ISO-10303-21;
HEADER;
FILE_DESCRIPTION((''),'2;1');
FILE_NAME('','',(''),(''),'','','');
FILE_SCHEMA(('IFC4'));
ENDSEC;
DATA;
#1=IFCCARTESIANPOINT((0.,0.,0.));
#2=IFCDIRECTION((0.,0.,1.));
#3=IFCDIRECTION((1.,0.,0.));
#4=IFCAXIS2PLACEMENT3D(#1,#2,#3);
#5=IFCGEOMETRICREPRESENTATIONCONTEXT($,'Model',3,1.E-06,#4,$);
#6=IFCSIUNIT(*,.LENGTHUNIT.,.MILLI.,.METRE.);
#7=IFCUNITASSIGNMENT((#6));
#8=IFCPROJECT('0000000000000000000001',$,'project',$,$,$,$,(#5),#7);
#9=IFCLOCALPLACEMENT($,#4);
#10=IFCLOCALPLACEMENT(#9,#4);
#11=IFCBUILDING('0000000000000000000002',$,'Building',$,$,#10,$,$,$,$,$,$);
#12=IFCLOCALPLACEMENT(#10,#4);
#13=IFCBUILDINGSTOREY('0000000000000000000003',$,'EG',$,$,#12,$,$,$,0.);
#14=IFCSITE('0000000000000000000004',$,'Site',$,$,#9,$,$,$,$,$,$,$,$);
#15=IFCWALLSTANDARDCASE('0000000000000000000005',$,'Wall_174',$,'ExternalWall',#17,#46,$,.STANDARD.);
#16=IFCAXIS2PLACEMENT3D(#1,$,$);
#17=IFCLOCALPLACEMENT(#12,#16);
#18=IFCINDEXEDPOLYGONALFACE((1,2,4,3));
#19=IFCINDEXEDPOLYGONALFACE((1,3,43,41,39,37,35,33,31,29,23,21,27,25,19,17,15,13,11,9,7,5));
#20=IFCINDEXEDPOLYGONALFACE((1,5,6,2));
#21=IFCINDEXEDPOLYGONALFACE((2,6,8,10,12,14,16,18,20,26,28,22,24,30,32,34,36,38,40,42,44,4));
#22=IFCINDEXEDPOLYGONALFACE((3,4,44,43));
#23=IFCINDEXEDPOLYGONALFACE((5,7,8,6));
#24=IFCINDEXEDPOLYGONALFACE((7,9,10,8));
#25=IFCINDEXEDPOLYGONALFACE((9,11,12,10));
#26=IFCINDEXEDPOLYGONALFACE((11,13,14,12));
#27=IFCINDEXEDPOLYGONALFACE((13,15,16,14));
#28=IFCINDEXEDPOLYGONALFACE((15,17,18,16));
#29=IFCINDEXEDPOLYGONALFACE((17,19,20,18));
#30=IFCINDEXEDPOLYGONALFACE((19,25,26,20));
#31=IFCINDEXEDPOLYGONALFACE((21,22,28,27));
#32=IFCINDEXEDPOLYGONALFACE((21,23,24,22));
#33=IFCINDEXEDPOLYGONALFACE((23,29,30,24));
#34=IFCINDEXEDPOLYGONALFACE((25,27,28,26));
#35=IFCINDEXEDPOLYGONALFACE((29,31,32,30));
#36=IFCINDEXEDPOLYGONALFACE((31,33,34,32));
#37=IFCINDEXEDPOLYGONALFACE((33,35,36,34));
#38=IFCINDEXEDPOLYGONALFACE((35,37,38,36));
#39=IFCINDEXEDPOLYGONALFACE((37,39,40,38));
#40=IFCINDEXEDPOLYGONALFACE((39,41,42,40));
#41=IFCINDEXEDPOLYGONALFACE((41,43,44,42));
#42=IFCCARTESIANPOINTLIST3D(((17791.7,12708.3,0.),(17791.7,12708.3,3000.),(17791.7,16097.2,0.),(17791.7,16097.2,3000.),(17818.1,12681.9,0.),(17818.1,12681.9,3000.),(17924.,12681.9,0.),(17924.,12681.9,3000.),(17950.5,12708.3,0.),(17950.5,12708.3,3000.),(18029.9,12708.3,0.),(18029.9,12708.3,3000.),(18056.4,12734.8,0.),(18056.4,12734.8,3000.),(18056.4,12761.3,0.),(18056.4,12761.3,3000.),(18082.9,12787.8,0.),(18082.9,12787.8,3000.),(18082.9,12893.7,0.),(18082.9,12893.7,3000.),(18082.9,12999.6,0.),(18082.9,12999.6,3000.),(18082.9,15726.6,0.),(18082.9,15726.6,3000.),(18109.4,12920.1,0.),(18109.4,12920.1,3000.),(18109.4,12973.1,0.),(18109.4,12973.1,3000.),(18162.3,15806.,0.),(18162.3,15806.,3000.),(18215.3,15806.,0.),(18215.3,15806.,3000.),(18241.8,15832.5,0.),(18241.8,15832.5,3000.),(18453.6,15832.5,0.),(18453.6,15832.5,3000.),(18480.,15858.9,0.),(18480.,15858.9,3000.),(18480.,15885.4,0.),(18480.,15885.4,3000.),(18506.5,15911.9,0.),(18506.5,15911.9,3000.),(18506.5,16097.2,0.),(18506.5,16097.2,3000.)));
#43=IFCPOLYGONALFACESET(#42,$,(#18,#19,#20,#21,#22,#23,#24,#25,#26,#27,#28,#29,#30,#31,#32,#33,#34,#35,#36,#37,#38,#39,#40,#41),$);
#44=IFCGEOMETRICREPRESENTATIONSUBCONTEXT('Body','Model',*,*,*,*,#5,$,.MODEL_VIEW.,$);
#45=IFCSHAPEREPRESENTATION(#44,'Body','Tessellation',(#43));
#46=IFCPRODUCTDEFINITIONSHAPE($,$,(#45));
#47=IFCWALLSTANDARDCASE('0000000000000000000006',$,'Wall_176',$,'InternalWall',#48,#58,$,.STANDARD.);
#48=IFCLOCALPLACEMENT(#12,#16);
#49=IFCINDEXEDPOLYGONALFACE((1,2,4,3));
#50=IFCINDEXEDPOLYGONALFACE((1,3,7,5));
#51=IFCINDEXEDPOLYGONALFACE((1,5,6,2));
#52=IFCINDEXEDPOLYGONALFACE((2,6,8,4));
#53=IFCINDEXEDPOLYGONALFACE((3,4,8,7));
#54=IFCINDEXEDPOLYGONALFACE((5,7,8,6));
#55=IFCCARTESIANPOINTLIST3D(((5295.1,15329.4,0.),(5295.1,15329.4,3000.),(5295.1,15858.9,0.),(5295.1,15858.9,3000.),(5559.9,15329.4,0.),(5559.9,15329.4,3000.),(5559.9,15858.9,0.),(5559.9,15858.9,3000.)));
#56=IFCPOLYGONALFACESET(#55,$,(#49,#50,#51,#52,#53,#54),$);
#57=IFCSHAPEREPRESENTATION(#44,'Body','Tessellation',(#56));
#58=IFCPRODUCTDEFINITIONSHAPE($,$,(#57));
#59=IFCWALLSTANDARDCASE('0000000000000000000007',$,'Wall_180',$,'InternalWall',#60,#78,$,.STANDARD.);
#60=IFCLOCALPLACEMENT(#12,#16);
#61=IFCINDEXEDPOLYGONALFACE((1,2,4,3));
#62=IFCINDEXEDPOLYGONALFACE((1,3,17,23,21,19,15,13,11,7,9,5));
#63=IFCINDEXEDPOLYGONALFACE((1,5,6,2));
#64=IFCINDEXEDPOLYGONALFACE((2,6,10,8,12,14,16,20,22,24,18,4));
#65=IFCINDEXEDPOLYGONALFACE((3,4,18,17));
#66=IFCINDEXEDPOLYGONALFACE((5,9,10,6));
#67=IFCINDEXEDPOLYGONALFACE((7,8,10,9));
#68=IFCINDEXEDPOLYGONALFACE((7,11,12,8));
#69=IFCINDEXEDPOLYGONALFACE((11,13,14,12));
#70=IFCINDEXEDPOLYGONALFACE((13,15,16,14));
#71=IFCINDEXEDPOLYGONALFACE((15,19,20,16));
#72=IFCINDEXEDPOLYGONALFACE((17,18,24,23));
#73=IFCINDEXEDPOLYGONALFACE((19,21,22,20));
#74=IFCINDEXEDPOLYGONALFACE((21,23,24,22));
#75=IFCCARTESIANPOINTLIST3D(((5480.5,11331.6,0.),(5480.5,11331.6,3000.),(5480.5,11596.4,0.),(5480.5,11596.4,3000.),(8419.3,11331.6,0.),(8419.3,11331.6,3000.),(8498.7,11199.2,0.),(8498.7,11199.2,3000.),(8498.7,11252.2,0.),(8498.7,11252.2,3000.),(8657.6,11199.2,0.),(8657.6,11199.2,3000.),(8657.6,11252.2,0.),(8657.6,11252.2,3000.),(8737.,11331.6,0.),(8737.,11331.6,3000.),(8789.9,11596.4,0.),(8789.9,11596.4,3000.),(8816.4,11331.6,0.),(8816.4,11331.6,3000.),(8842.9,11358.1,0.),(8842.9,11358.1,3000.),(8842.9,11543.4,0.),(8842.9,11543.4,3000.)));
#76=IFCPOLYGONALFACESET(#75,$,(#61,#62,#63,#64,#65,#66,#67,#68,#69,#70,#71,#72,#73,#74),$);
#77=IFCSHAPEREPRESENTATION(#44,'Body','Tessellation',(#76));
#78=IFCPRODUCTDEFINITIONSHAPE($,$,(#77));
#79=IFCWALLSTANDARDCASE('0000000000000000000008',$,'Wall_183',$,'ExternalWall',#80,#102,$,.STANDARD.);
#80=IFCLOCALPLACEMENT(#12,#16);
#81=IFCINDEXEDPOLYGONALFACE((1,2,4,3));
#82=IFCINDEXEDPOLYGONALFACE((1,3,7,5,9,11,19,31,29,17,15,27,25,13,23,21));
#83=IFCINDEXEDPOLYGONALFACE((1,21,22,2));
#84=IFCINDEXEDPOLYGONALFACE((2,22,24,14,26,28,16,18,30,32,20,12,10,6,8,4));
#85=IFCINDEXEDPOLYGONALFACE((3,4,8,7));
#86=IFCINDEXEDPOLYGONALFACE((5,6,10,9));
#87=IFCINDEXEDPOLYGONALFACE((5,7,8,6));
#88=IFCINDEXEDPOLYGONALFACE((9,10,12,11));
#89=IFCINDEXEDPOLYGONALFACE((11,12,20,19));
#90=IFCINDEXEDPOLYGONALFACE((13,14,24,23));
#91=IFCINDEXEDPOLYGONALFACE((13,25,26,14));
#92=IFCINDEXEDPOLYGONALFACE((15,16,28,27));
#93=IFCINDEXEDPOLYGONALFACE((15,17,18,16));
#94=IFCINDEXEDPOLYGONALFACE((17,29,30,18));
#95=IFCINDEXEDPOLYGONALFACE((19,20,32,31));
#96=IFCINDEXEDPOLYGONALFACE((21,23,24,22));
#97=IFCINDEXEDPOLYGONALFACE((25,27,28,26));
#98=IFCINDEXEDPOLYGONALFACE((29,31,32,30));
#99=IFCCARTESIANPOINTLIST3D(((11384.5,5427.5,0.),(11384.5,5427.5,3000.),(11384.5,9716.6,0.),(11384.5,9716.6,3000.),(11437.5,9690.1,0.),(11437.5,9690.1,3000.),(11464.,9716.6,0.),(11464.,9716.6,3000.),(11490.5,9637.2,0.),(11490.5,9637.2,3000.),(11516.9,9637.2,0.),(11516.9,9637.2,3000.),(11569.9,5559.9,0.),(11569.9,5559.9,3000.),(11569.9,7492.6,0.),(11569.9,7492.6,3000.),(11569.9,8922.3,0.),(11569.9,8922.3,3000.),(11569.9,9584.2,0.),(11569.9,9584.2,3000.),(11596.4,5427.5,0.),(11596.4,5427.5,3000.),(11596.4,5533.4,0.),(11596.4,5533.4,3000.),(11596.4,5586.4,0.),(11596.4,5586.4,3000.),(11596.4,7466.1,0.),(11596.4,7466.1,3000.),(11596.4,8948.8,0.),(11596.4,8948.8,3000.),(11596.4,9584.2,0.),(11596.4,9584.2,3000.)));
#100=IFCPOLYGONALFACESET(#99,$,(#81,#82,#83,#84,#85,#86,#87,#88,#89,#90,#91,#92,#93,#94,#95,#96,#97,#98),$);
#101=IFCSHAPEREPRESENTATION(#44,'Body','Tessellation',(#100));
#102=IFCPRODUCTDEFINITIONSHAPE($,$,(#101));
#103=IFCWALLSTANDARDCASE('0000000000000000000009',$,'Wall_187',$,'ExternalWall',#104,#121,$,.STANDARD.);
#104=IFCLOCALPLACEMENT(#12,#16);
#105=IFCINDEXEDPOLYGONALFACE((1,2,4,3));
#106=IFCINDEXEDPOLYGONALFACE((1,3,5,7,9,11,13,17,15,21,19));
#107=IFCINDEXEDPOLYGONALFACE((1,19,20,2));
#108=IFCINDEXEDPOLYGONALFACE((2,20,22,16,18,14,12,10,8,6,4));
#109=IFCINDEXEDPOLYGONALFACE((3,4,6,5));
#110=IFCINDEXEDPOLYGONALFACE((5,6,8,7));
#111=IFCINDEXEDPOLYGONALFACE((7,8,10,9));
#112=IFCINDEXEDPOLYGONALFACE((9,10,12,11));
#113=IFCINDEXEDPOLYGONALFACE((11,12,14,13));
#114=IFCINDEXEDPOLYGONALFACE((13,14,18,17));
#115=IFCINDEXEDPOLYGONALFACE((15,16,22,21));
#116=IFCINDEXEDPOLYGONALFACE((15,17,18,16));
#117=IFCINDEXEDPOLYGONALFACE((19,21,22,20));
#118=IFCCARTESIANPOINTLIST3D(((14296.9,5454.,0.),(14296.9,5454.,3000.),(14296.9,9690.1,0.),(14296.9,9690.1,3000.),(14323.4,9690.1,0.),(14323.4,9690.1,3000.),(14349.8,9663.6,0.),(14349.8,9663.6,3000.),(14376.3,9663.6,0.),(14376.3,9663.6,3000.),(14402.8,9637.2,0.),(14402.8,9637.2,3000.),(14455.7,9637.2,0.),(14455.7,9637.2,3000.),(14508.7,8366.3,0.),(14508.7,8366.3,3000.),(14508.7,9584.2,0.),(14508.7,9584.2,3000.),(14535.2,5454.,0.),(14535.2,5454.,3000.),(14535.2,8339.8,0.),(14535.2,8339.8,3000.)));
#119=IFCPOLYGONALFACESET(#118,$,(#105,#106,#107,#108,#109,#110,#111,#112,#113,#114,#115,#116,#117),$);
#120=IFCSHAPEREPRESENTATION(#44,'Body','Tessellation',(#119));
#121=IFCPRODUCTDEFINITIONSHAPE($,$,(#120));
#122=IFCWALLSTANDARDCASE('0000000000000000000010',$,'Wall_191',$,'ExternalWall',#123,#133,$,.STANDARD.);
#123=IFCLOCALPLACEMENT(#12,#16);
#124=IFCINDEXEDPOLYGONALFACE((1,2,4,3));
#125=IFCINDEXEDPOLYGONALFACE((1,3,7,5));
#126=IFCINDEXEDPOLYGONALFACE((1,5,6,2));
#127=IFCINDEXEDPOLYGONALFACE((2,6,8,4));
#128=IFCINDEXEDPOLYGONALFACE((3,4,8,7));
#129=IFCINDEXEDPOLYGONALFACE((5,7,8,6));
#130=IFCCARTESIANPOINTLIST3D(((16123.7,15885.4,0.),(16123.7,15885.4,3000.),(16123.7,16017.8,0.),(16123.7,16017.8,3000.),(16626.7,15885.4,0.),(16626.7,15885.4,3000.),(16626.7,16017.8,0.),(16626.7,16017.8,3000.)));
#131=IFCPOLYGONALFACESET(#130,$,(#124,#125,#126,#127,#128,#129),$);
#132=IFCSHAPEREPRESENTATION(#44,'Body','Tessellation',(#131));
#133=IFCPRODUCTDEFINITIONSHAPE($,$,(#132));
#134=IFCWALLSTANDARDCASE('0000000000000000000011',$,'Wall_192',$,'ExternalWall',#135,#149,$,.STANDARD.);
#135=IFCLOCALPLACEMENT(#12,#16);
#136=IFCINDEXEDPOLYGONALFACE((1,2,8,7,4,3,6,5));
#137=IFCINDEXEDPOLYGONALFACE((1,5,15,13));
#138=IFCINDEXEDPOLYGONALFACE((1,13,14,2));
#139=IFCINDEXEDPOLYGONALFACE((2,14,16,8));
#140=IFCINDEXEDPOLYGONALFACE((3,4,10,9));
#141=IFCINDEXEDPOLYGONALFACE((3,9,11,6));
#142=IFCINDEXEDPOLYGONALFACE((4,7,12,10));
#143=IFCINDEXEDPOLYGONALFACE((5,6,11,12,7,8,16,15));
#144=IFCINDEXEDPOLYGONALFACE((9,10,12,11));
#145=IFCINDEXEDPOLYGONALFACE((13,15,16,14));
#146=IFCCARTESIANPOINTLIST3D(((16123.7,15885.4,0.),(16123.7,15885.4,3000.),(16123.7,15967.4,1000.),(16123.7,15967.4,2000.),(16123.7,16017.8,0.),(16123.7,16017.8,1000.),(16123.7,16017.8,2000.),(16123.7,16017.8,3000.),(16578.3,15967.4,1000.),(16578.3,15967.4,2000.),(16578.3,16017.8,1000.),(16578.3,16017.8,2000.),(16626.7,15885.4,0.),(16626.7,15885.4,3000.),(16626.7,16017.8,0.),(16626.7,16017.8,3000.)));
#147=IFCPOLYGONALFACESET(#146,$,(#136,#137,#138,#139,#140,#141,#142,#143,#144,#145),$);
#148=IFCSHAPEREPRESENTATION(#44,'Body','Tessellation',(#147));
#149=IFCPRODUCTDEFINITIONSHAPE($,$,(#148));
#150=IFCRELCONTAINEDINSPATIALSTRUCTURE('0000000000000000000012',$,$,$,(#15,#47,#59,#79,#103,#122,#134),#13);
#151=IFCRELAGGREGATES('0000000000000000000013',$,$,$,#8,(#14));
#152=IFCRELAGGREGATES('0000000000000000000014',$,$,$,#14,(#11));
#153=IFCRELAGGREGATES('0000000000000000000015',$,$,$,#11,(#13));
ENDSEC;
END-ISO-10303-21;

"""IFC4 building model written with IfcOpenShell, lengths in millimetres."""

from ifc_helpers import new_model, si_unit, frame, origin_with_axes, place, context, subcontext, project, spatial, polyline, rectangle, outline, extrude, element, save


model = new_model("IFC4")

# Units and contexts
model_context = context("Model", 3, precision=1e-06, world=origin_with_axes())
body_context = subcontext(model_context, "Body", "Model", "MODEL_VIEW")
ifc_project = project(units=[si_unit("LENGTHUNIT", "METRE", prefix="MILLI")], contexts=[model_context])

# Site, building, storey
site_placement = place(None, origin_with_axes())
site = spatial("IfcSite", under=ifc_project, at=site_placement, Name="Site")
building_placement = place(site_placement, origin_with_axes())
building = spatial("IfcBuilding", under=site, at=building_placement, Name="Building")
storey_placement = place(building_placement, origin_with_axes())
storey = spatial("IfcBuildingStorey", under=building, at=storey_placement, Name="EG", Elevation=0.0)

# Walls
for number, where, z_axis, x_axis, name in (
    (1, (0.0, 0.0, 0.0), (0.0, 0.0, 1.0), (1.0, 0.0, 0.0), "Wall_174"),
):
    element("IfcWallStandardCase", number, at=place(storey_placement, frame(where, z_axis=z_axis, x_axis=x_axis)), inside=storey, Name=name, ObjectType="ExternalWall", PredefinedType="STANDARD", context=body_context, shape_type="SweptSolid", body=[
        extrude(outline(polyline([(17818.1, 12681.9, 0.0), (17791.7, 12708.3, 0.0), (17791.7, 16097.2, 0.0), (18506.5, 16097.2, 0.0), (18506.5, 15911.9, 0.0), (18480.0, 15885.4, 0.0), (18480.0, 15858.9, 0.0), (18453.6, 15832.5, 0.0), (18241.8, 15832.5, 0.0), (18215.3, 15806.0, 0.0), (18162.3, 15806.0, 0.0), (18082.9, 15726.6, 0.0), (18082.9, 12999.6, 0.0), (18109.4, 12973.1, 0.0), (18109.4, 12920.1, 0.0), (18082.9, 12893.7, 0.0), (18082.9, 12787.8, 0.0), (18056.4, 12761.3, 0.0), (18056.4, 12734.8, 0.0), (18029.9, 12708.3, 0.0), (17950.5, 12708.3, 0.0), (17924.0, 12681.9, 0.0), (17818.1, 12681.9, 0.0)])), origin_with_axes(), (0.0, 0.0, 1.0), 3000.0),
    ])
for number, where, z_axis, x_axis, name in (
    (2, (0.0, 0.0, 0.0), (0.0, 0.0, 1.0), (1.0, 0.0, 0.0), "Wall_176"),
):
    element("IfcWallStandardCase", number, at=place(storey_placement, frame(where, z_axis=z_axis, x_axis=x_axis)), inside=storey, Name=name, ObjectType="InternalWall", PredefinedType="STANDARD", context=body_context, shape_type="SweptSolid", body=[
        extrude(outline(polyline([(5295.1, 15329.4, 0.0), (5295.1, 15858.9, 0.0), (5559.9, 15858.9, 0.0), (5559.9, 15329.4, 0.0), (5295.1, 15329.4, 0.0)])), origin_with_axes(), (0.0, 0.0, 1.0), 3000.0),
    ])
for number, where, z_axis, x_axis, name in (
    (3, (0.0, 0.0, 0.0), (0.0, 0.0, 1.0), (1.0, 0.0, 0.0), "Wall_180"),
):
    element("IfcWallStandardCase", number, at=place(storey_placement, frame(where, z_axis=z_axis, x_axis=x_axis)), inside=storey, Name=name, ObjectType="InternalWall", PredefinedType="STANDARD", context=body_context, shape_type="SweptSolid", body=[
        extrude(outline(polyline([(8498.7, 11199.2, 0.0), (8498.7, 11252.2, 0.0), (8419.3, 11331.6, 0.0), (5480.5, 11331.6, 0.0), (5480.5, 11596.4, 0.0), (8789.9, 11596.4, 0.0), (8842.9, 11543.4, 0.0), (8842.9, 11358.1, 0.0), (8816.4, 11331.6, 0.0), (8737.0, 11331.6, 0.0), (8657.6, 11252.2, 0.0), (8657.6, 11199.2, 0.0), (8498.7, 11199.2, 0.0)])), origin_with_axes(), (0.0, 0.0, 1.0), 3000.0),
    ])
for number, where, z_axis, x_axis, name in (
    (4, (0.0, 0.0, 0.0), (0.0, 0.0, 1.0), (1.0, 0.0, 0.0), "Wall_183"),
):
    element("IfcWallStandardCase", number, at=place(storey_placement, frame(where, z_axis=z_axis, x_axis=x_axis)), inside=storey, Name=name, ObjectType="ExternalWall", PredefinedType="STANDARD", context=body_context, shape_type="SweptSolid", body=[
        extrude(outline(polyline([(11384.5, 5427.5, 0.0), (11384.5, 9716.6, 0.0), (11464.0, 9716.6, 0.0), (11437.5, 9690.1, 0.0), (11490.5, 9637.2, 0.0), (11516.9, 9637.2, 0.0), (11569.9, 9584.2, 0.0), (11596.4, 9584.2, 0.0), (11596.4, 8948.8, 0.0), (11569.9, 8922.3, 0.0), (11569.9, 7492.6, 0.0), (11596.4, 7466.1, 0.0), (11596.4, 5586.4, 0.0), (11569.9, 5559.9, 0.0), (11596.4, 5533.4, 0.0), (11596.4, 5427.5, 0.0), (11384.5, 5427.5, 0.0)])), origin_with_axes(), (0.0, 0.0, 1.0), 3000.0),
    ])
for number, where, z_axis, x_axis, name in (
    (5, (0.0, 0.0, 0.0), (0.0, 0.0, 1.0), (1.0, 0.0, 0.0), "Wall_187"),
):
    element("IfcWallStandardCase", number, at=place(storey_placement, frame(where, z_axis=z_axis, x_axis=x_axis)), inside=storey, Name=name, ObjectType="ExternalWall", PredefinedType="STANDARD", context=body_context, shape_type="SweptSolid", body=[
        extrude(outline(polyline([(14296.9, 5454.0, 0.0), (14296.9, 9690.1, 0.0), (14323.4, 9690.1, 0.0), (14349.8, 9663.6, 0.0), (14376.3, 9663.6, 0.0), (14402.8, 9637.2, 0.0), (14455.7, 9637.2, 0.0), (14508.7, 9584.2, 0.0), (14508.7, 8366.3, 0.0), (14535.2, 8339.8, 0.0), (14535.2, 5454.0, 0.0), (14296.9, 5454.0, 0.0)])), origin_with_axes(), (0.0, 0.0, 1.0), 3000.0),
    ])
wall_1_placement = place(storey_placement, origin_with_axes())
element("IfcWallStandardCase", 6, at=wall_1_placement, inside=storey, Name="Wall_191", ObjectType="ExternalWall", PredefinedType="STANDARD", context=body_context, shape_type="SweptSolid", body=[
    extrude(outline(polyline([(16123.7, 15885.4, 0.0), (16123.7, 16017.8, 0.0), (16626.7, 16017.8, 0.0), (16626.7, 15885.4, 0.0), (16123.7, 15885.4, 0.0)])), origin_with_axes(), (0.0, 0.0, 1.0), 3000.0),
])

# Wall, opening
wall_2_placement = place(storey_placement, origin_with_axes())
wall_2 = element("IfcWallStandardCase", 7, at=wall_2_placement, inside=storey, Name="Wall_192", ObjectType="ExternalWall", PredefinedType="STANDARD", context=body_context, shape_type="SweptSolid", body=[
    extrude(outline(polyline([(16123.7, 15885.4, 0.0), (16123.7, 16017.8, 0.0), (16626.7, 16017.8, 0.0), (16626.7, 15885.4, 0.0), (16123.7, 15885.4, 0.0)])), origin_with_axes(), (0.0, 0.0, 1.0), 3000.0),
])
opening_placement = place(wall_2_placement, origin_with_axes())
element("IfcOpeningElement", 8, at=opening_placement, inside=storey, cuts=wall_2, context=body_context, shape_type="SweptSolid", body=[
    extrude(rectangle(XDim=842.5, YDim=69.4), frame((16157.0, 16002.1, 1000.0), z_axis=(0.0, 0.0, 1.0), x_axis=(1.0, 0.0, 0.0)), (0.0, 0.0, 1.0), 1000.0),
])

save(model, "model.ifc")
